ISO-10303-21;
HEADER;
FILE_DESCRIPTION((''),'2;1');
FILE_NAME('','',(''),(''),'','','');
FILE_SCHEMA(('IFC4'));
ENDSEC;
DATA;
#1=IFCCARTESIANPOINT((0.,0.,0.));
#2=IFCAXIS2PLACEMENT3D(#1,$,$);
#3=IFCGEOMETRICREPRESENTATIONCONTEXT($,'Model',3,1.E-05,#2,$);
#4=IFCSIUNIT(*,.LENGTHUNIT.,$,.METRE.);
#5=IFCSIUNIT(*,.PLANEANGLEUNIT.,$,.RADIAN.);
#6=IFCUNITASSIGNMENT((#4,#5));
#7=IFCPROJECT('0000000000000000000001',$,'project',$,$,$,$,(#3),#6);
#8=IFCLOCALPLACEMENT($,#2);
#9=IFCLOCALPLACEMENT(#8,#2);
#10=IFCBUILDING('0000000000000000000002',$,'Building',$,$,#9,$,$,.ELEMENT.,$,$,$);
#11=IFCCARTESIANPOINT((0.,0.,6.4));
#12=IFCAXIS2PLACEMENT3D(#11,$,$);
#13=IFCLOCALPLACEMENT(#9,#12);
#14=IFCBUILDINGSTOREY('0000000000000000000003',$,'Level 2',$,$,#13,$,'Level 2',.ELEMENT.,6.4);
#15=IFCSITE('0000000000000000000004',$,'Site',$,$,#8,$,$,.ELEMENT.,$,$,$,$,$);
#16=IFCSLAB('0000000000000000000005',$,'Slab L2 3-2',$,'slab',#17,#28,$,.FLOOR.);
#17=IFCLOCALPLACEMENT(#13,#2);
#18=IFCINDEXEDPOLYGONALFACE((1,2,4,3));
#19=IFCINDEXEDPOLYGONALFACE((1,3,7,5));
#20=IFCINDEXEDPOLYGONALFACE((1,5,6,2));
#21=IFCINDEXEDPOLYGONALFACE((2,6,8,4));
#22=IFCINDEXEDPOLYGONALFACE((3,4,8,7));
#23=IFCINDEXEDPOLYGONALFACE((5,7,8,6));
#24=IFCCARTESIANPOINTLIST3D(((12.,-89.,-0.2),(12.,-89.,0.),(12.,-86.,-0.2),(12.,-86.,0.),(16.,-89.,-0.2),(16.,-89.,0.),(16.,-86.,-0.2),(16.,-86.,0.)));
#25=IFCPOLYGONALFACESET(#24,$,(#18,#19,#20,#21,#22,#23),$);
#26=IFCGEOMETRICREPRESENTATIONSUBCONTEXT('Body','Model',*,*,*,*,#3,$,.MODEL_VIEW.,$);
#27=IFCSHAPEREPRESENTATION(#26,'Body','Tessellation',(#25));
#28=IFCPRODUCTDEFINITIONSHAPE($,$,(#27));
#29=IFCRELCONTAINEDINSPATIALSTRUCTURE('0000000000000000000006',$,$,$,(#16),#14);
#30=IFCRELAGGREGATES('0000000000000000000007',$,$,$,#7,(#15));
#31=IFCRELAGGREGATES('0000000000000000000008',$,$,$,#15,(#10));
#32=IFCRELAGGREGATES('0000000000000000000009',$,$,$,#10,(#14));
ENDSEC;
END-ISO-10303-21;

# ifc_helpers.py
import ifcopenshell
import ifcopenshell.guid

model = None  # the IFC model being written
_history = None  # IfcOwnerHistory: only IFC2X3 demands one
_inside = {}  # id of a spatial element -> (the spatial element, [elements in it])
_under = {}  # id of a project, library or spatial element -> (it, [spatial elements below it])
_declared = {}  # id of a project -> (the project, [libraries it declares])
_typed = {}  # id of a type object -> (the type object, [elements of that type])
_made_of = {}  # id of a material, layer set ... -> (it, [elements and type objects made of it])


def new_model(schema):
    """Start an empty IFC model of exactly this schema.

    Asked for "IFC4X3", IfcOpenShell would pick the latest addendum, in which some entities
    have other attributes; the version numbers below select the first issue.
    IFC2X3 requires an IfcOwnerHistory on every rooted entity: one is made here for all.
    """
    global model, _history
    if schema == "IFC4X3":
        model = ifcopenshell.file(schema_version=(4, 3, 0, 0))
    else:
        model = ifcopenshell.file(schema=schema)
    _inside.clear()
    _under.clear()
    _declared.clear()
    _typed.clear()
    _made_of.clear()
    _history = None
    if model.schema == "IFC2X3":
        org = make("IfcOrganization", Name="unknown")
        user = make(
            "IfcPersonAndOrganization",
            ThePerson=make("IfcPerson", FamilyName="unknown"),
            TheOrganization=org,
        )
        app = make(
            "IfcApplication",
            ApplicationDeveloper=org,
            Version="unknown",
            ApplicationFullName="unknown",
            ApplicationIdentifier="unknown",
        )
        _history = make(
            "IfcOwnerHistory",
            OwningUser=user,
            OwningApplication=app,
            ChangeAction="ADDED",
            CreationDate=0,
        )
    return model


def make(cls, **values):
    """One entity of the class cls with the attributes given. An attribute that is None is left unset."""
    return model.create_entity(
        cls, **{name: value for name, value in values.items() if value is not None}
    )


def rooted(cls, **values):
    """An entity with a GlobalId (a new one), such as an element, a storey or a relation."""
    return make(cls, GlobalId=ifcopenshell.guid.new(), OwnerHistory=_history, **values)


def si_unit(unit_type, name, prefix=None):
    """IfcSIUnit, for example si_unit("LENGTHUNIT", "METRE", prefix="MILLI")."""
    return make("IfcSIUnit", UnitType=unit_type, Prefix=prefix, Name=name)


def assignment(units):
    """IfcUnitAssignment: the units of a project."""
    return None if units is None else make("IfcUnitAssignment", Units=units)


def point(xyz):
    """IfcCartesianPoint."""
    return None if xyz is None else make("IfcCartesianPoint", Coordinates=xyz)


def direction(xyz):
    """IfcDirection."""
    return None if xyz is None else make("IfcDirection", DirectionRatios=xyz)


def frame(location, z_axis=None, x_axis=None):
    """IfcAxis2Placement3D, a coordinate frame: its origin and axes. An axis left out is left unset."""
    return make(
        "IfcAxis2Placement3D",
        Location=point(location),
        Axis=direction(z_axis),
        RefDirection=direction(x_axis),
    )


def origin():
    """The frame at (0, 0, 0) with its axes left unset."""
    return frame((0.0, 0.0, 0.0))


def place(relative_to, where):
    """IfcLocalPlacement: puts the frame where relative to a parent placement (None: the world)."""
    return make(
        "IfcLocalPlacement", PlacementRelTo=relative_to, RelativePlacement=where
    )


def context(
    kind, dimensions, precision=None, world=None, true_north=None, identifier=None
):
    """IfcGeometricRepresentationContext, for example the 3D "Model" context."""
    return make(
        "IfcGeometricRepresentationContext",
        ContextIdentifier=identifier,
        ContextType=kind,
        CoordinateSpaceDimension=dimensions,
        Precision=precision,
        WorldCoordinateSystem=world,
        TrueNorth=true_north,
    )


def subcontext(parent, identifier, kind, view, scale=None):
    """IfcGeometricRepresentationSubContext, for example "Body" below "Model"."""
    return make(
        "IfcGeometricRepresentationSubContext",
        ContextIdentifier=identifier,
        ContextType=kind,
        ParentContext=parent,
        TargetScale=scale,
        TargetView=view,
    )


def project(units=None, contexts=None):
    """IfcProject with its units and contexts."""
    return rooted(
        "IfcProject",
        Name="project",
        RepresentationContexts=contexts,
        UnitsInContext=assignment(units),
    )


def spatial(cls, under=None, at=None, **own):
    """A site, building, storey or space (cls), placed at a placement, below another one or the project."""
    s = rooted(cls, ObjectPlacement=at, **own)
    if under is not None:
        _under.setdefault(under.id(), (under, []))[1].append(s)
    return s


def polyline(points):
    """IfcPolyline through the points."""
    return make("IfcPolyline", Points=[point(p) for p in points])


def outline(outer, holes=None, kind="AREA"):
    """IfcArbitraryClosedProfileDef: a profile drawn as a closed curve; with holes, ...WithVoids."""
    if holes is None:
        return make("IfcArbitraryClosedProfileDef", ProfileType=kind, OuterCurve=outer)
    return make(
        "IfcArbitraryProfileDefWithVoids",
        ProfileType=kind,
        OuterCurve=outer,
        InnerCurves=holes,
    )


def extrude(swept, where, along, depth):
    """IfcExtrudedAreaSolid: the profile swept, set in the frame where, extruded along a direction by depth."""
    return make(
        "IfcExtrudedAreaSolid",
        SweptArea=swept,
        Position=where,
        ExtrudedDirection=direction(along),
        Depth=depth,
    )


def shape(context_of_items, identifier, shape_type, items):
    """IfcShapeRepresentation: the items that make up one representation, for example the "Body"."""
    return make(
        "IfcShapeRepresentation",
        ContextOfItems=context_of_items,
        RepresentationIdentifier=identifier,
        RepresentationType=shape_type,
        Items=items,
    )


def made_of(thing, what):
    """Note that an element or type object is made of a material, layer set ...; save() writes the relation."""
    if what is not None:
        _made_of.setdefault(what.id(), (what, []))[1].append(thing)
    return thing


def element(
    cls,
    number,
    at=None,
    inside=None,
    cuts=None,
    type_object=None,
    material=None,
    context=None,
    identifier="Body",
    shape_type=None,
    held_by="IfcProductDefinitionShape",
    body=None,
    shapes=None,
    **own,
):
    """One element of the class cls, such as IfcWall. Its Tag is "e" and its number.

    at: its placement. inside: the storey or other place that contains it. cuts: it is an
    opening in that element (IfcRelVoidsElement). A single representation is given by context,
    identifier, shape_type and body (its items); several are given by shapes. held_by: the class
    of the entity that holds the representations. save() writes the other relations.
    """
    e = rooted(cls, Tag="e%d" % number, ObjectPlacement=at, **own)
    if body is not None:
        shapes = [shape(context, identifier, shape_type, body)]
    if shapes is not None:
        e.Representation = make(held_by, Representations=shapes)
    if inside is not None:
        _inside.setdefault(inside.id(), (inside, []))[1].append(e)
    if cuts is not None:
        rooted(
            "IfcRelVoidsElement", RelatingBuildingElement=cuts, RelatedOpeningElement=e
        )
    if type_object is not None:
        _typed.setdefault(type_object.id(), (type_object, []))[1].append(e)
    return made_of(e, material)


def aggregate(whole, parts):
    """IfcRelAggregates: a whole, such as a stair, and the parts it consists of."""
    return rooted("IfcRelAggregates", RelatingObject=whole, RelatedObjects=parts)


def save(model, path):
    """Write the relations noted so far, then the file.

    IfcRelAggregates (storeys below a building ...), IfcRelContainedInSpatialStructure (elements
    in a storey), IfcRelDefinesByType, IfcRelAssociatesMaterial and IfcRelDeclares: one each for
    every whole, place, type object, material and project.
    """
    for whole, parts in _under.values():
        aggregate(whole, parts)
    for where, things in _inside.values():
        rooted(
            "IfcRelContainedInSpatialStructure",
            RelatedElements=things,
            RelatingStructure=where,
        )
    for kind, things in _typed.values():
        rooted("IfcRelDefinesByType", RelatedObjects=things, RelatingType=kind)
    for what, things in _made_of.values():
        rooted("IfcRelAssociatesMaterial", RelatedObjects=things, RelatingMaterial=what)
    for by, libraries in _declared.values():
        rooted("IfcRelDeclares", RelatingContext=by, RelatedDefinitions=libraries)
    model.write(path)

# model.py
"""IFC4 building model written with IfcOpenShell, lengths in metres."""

from ifc_helpers import new_model, si_unit, frame, origin, place, context, subcontext, project, spatial, polyline, outline, extrude, element, save


model = new_model("IFC4")

# Units and contexts
model_context = context("Model", 3, precision=1e-05, world=origin())
body_context = subcontext(model_context, "Body", "Model", "MODEL_VIEW")
ifc_project = project(units=[si_unit("LENGTHUNIT", "METRE"), si_unit("PLANEANGLEUNIT", "RADIAN")], contexts=[model_context])

# Site, building, storey
site_placement = place(None, origin())
site = spatial("IfcSite", under=ifc_project, at=site_placement, Name="Site", CompositionType="ELEMENT")
building_placement = place(site_placement, origin())
building = spatial("IfcBuilding", under=site, at=building_placement, Name="Building", CompositionType="ELEMENT")
storey_placement = place(building_placement, frame((0.0, 0.0, 6.4)))
storey = spatial("IfcBuildingStorey", under=building, at=storey_placement, Name="Level 2", LongName="Level 2", CompositionType="ELEMENT", Elevation=6.4)

# Slab
slab_1_placement = place(storey_placement, frame((0.0, 0.0, -0.2)))
element("IfcSlab", 1, at=slab_1_placement, inside=storey, Name="Slab L2 3-2", ObjectType="slab", PredefinedType="FLOOR", context=body_context, shape_type="SweptSolid", body=[
    extrude(outline(polyline([(12.0, -89.0), (16.0, -89.0), (16.0, -86.0), (12.0, -86.0), (12.0, -89.0)])), origin(), (0.0, 0.0, 1.0), 0.2),
])

save(model, "model.ifc")
